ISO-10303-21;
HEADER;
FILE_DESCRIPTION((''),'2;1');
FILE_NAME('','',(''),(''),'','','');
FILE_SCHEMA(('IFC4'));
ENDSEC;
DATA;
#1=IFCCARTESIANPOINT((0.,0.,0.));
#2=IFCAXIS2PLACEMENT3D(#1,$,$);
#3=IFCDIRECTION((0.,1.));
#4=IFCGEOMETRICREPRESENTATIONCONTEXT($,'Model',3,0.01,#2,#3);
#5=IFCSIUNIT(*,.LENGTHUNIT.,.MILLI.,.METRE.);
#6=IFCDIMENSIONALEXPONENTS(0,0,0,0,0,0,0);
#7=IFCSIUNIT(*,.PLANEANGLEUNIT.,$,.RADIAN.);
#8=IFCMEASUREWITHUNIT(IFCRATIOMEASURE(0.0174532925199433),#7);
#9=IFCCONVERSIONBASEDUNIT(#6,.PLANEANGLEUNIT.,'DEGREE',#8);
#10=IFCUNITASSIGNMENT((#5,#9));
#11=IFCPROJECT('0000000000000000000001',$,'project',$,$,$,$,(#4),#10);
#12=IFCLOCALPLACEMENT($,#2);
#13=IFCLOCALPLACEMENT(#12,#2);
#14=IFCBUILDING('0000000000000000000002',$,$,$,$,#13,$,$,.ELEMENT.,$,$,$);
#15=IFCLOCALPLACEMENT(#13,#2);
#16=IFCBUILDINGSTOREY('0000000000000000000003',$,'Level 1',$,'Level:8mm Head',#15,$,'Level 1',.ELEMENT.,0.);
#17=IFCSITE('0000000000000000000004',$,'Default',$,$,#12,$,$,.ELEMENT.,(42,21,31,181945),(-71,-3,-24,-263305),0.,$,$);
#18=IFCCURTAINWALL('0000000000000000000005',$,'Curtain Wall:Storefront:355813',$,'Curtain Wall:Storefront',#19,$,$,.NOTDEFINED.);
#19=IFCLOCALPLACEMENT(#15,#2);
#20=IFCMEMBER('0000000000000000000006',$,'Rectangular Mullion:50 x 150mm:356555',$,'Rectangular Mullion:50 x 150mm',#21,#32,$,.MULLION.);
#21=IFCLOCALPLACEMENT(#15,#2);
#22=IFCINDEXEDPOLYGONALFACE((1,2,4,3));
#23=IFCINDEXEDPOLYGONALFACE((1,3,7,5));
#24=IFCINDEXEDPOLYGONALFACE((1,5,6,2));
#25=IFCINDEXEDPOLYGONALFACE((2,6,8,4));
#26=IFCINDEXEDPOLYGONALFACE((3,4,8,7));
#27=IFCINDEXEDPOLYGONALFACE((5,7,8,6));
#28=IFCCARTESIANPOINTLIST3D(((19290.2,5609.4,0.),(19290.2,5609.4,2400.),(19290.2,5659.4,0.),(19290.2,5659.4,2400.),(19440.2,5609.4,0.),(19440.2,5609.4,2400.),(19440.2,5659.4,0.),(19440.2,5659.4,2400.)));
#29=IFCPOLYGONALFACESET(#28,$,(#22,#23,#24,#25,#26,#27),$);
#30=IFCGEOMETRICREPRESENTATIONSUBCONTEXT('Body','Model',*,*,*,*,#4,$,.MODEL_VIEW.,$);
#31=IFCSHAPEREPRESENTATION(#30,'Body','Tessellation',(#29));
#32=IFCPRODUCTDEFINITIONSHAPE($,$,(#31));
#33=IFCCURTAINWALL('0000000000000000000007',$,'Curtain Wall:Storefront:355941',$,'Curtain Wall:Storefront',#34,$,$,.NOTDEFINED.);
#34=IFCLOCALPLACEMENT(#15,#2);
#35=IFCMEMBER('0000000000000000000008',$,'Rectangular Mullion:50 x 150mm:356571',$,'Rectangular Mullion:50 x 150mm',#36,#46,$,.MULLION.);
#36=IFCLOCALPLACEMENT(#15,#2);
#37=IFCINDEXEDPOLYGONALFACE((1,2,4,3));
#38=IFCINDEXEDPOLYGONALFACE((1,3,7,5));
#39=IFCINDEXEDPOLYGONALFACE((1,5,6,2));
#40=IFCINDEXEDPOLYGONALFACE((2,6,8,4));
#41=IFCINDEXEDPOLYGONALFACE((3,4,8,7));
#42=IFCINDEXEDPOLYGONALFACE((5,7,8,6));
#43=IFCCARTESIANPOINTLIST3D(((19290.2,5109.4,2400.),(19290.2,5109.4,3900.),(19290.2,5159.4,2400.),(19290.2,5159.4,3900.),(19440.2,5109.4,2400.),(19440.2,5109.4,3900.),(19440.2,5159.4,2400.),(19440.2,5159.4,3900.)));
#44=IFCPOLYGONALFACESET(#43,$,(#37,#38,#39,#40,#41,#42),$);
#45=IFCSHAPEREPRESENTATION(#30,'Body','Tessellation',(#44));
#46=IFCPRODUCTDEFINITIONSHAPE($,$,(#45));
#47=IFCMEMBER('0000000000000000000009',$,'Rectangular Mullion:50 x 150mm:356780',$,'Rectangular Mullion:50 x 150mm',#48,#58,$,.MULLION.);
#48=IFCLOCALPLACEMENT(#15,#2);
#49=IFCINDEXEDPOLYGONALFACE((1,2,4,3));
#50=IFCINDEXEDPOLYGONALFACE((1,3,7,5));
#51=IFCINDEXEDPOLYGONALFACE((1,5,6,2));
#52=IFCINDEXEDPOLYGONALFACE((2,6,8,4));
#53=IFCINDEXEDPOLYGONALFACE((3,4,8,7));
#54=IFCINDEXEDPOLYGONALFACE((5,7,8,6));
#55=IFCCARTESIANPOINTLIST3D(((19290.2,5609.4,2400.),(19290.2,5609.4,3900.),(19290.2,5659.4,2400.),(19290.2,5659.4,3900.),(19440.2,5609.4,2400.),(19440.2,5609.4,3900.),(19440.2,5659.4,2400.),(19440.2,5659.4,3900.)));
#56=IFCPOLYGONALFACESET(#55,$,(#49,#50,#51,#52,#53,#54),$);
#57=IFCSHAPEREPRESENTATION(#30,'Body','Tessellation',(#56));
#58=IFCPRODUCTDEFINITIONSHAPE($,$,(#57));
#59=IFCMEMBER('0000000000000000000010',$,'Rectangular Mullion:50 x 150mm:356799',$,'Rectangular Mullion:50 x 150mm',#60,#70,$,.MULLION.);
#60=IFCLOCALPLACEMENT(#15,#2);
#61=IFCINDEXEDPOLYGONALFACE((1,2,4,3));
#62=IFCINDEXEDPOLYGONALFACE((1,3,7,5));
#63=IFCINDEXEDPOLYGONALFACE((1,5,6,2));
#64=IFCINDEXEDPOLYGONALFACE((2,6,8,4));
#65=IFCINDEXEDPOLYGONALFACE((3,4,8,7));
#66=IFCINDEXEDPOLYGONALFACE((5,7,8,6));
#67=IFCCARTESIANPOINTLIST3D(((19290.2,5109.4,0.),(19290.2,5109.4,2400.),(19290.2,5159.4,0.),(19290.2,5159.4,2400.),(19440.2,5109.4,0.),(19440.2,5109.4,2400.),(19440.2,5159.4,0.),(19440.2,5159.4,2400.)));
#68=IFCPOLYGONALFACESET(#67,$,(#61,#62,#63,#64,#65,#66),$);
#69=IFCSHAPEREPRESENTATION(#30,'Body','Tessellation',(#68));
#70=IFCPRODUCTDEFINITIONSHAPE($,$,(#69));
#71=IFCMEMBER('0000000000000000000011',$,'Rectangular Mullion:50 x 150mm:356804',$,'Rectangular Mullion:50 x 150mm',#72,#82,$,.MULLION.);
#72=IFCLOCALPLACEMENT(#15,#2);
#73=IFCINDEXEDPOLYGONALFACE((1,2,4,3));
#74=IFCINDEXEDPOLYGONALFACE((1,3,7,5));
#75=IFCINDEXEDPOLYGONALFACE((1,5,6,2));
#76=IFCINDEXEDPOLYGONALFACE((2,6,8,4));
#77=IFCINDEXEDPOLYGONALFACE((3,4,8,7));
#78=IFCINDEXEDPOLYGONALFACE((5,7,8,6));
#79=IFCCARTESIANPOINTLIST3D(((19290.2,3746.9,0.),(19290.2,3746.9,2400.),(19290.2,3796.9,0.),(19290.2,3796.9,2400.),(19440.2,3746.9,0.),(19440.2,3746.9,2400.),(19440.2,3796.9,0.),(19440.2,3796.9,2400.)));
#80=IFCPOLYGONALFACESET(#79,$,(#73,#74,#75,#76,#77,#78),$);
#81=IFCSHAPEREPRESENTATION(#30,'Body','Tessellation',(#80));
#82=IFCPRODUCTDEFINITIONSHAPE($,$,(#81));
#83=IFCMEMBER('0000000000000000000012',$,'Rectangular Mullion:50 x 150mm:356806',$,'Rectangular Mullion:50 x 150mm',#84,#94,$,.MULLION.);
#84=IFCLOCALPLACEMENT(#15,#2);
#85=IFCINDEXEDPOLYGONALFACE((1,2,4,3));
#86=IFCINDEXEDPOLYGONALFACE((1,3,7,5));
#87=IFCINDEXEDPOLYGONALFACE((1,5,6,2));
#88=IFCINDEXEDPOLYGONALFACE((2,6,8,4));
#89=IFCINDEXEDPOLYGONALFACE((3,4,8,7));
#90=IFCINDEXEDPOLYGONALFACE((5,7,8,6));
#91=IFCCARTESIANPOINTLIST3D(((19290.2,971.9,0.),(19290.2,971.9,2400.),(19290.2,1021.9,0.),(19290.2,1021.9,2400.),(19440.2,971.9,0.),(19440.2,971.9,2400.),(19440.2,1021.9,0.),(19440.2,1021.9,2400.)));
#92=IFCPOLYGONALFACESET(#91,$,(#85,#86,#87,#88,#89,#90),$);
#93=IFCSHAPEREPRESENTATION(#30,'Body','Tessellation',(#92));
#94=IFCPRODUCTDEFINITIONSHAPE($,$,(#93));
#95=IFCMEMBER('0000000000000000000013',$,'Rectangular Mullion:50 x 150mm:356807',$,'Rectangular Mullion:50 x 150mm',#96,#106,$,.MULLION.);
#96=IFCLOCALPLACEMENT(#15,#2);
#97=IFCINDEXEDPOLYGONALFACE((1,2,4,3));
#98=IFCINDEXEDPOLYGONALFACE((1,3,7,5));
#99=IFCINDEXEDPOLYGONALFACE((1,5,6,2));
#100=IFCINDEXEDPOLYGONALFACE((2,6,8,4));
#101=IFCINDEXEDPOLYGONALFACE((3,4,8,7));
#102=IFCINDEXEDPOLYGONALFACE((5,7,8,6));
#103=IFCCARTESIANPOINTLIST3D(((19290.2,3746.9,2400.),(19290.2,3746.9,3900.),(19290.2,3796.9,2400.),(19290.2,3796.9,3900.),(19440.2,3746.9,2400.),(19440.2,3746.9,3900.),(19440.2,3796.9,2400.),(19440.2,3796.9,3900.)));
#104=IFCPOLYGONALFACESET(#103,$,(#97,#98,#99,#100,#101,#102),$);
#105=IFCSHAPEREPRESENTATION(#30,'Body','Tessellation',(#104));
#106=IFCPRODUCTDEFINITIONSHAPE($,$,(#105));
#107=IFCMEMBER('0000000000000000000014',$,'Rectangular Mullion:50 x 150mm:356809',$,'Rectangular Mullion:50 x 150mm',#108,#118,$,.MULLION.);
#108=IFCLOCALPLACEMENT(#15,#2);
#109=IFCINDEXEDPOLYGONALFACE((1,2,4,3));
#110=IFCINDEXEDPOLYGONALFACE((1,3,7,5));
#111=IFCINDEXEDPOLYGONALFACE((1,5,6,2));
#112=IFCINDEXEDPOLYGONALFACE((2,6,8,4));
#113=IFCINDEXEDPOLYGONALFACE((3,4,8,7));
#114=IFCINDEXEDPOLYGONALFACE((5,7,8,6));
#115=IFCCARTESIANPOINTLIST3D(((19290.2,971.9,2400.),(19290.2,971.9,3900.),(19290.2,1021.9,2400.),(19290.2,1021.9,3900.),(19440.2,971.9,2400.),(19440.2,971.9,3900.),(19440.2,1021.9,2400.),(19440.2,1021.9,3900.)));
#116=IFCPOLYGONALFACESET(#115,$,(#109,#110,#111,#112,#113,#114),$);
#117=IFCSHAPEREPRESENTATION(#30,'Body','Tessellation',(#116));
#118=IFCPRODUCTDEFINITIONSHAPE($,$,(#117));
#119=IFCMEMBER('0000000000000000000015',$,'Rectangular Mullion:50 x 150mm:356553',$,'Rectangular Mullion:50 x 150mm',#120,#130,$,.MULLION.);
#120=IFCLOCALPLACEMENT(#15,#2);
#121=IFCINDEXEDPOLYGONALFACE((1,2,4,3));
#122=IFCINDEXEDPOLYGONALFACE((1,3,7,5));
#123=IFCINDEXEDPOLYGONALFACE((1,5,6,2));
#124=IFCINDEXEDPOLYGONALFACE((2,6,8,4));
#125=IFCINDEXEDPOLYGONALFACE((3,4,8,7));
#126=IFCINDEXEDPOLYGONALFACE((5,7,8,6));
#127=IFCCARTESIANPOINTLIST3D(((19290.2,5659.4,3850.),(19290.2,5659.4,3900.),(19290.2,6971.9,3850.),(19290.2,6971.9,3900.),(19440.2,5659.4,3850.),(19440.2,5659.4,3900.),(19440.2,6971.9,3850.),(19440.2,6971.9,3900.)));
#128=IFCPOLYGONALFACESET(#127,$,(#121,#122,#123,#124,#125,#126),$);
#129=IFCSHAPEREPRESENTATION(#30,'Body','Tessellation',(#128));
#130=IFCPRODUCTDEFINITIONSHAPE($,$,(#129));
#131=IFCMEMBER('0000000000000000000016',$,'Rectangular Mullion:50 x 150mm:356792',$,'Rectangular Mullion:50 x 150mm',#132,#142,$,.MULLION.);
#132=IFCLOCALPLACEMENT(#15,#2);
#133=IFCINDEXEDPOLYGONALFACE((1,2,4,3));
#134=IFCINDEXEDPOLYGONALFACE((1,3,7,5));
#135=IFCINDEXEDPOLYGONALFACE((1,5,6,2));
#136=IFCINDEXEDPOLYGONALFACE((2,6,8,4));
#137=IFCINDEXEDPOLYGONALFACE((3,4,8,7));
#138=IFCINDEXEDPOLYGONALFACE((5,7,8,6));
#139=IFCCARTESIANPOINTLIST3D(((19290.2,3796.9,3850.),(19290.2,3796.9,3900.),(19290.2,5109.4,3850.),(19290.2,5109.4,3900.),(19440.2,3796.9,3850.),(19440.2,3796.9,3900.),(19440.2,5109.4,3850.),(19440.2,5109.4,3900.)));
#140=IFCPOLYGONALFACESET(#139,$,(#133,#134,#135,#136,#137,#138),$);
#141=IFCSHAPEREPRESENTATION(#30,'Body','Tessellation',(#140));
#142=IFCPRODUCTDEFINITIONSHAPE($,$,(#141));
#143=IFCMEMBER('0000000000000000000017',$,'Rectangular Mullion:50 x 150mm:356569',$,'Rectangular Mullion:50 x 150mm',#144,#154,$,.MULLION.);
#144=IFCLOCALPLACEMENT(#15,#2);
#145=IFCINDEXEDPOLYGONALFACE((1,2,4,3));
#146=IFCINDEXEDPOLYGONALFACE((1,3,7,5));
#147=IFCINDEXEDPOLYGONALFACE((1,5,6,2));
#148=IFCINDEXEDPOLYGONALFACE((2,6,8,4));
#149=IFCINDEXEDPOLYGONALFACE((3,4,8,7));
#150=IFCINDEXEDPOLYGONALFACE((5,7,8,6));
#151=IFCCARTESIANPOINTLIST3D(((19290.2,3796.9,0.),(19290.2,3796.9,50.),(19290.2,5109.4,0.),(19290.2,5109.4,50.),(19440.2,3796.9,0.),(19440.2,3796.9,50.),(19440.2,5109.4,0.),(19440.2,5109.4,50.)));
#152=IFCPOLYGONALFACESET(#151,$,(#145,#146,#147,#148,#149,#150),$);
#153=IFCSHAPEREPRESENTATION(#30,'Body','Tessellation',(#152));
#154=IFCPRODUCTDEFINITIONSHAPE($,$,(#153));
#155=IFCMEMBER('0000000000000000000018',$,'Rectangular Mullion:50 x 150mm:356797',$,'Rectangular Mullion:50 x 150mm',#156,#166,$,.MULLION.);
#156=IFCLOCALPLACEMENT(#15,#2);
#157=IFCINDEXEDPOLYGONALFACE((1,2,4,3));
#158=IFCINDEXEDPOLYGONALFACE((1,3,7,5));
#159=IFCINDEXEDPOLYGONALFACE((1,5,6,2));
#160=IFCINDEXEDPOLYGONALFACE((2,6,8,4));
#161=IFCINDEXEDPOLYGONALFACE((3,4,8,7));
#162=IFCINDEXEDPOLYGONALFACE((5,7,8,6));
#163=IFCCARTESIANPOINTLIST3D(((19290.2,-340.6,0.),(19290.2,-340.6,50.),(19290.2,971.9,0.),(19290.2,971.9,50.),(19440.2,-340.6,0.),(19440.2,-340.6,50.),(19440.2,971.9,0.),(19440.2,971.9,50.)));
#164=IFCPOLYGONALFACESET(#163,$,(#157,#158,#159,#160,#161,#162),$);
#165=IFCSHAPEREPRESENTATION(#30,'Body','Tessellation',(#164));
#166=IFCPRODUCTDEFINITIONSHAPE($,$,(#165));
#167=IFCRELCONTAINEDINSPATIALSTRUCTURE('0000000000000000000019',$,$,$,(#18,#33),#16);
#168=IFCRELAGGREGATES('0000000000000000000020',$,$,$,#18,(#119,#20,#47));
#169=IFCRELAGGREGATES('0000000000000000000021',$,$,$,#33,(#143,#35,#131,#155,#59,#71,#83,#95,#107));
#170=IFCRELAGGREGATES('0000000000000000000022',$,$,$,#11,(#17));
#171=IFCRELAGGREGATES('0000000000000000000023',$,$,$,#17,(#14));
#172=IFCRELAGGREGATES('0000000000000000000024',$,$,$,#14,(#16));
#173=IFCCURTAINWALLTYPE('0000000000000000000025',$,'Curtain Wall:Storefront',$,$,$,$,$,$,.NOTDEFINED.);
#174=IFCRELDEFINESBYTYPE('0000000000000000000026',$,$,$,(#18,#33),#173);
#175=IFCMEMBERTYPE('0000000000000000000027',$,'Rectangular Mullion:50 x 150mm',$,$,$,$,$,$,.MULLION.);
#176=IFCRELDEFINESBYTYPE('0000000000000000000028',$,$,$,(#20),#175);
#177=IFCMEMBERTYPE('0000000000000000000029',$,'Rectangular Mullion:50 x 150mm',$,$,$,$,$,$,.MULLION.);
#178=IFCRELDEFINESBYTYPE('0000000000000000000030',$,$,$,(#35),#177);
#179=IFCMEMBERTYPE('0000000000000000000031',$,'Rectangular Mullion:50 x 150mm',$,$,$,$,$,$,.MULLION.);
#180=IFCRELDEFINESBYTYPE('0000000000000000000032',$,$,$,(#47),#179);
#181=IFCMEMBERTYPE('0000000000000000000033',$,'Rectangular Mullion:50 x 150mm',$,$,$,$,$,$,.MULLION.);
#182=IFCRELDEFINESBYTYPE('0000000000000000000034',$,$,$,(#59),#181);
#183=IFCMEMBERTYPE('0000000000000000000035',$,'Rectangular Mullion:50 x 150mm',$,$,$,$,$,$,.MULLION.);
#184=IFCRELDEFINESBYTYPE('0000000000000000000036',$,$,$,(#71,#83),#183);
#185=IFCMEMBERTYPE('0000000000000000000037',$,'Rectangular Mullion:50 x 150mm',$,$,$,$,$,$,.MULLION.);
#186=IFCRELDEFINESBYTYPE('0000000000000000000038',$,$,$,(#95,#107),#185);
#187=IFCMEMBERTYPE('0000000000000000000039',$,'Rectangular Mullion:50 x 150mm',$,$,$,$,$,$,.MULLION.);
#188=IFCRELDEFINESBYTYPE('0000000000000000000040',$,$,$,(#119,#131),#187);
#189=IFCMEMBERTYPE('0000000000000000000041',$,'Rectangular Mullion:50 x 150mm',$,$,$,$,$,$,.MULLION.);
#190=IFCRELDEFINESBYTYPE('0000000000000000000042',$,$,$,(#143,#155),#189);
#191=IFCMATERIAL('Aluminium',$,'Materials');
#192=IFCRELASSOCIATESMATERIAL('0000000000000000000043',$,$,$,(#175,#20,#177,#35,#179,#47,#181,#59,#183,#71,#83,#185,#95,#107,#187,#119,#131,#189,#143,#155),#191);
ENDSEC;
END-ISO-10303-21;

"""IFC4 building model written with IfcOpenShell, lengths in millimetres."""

from ifc_helpers import new_model, entity, si_unit, converted_unit, direction, frame, origin, place, context, subcontext, project, spatial, indexed_curve, outline, extrude, source, transform, mapped, material, type_object, type_shapes, element, aggregate, save


model = new_model("IFC4")

# Units and contexts
model_context = context("Model", 3, precision=0.01, world=origin(), true_north=direction((0.0, 1.0)))
body_context = subcontext(model_context, "Body", "Model", "MODEL_VIEW")
ifc_project = project(units=[si_unit("LENGTHUNIT", "METRE", prefix="MILLI"), converted_unit("PLANEANGLEUNIT", "DEGREE", entity("IfcRatioMeasure", 0.0174532925199433), si_unit("PLANEANGLEUNIT", "RADIAN"), dimensions=[0, 0, 0, 0, 0, 0, 0])], contexts=[model_context])

# Site, building, storey
site_placement = place(None, origin())
site = spatial("IfcSite", under=ifc_project, at=site_placement, Name="Default", CompositionType="ELEMENT", RefLatitude=(42, 21, 31, 181945), RefLongitude=(-71, -3, -24, -263305), RefElevation=0.0)
building_placement = place(site_placement, origin())
building = spatial("IfcBuilding", under=site, at=building_placement, CompositionType="ELEMENT")
storey_placement = place(building_placement, origin())
storey = spatial("IfcBuildingStorey", under=building, at=storey_placement, Name="Level 1", ObjectType="Level:8mm Head", LongName="Level 1", CompositionType="ELEMENT", Elevation=0.0)

# Curtain walls, members
curtain_wall_type_1 = type_object("IfcCurtainWallType", Name="Curtain Wall:Storefront", PredefinedType="NOTDEFINED")
curtain_wall_1_placement = place(storey_placement, origin())
curtain_wall_1 = element("IfcCurtainWall", 1, at=curtain_wall_1_placement, inside=storey, type_object=curtain_wall_type_1, Name="Curtain Wall:Storefront:355813", ObjectType="Curtain Wall:Storefront", PredefinedType="NOTDEFINED")
ifc_material_1 = material(Name="Aluminium", Category="Materials")
member_type_1 = type_object("IfcMemberType", Name="Rectangular Mullion:50 x 150mm", PredefinedType="MULLION", material=ifc_material_1)
shared_shape_1 = source(origin(), body_context, "Body", "SweptSolid", [
    extrude(outline(indexed_curve([(-75.0, -25.0), (75.0, -25.0), (75.0, 25.0), (-75.0, 25.0), (-75.0, -25.0)], self_intersect=False)), frame((-25.0, 0.0, -2400.0), z_axis=(0.0, 0.0, 1.0), x_axis=(0.0, -1.0, 0.0)), (0.0, 0.0, 1.0), 2400.0),
])
type_shapes(member_type_1, [shared_shape_1])
member_1_placement = place(storey_placement, frame((19365.2, 5609.4, 0.0), z_axis=(0.0, 0.0, -1.0), x_axis=(0.0, -1.0, 0.0)))
member_1 = element("IfcMember", 2, at=member_1_placement, type_object=member_type_1, material=ifc_material_1, Name="Rectangular Mullion:50 x 150mm:356555", ObjectType="Rectangular Mullion:50 x 150mm", PredefinedType="MULLION", context=body_context, shape_type="MappedRepresentation", body=[
    mapped(shared_shape_1, transform((0.0, 0.0, 0.0), scale=1.0)),
])
curtain_wall_2_placement = place(storey_placement, origin())
curtain_wall_2 = element("IfcCurtainWall", 3, at=curtain_wall_2_placement, inside=storey, type_object=curtain_wall_type_1, Name="Curtain Wall:Storefront:355941", ObjectType="Curtain Wall:Storefront", PredefinedType="NOTDEFINED")
member_type_2 = type_object("IfcMemberType", Name="Rectangular Mullion:50 x 150mm", PredefinedType="MULLION", material=ifc_material_1)
shared_shape_2 = source(origin(), body_context, "Body", "SweptSolid", [
    extrude(outline(indexed_curve([(-75.0, -25.0), (75.0, -25.0), (75.0, 25.0), (-75.0, 25.0), (-75.0, -25.0)], self_intersect=False)), frame((-25.0, 0.0, -1500.0), z_axis=(0.0, 0.0, 1.0), x_axis=(0.0, -1.0, 0.0)), (0.0, 0.0, 1.0), 1500.0),
])
type_shapes(member_type_2, [shared_shape_2])
member_2_placement = place(storey_placement, frame((19365.2, 5159.4, 3900.0), z_axis=(0.0, 0.0, 1.0), x_axis=(0.0, 1.0, 0.0)))
member_2 = element("IfcMember", 4, at=member_2_placement, type_object=member_type_2, material=ifc_material_1, Name="Rectangular Mullion:50 x 150mm:356571", ObjectType="Rectangular Mullion:50 x 150mm", PredefinedType="MULLION", context=body_context, shape_type="MappedRepresentation", body=[
    mapped(shared_shape_2, transform((0.0, 0.0, 0.0), scale=1.0)),
])

# Members
member_type_3 = type_object("IfcMemberType", Name="Rectangular Mullion:50 x 150mm", PredefinedType="MULLION", material=ifc_material_1)
shared_shape_3 = source(origin(), body_context, "Body", "SweptSolid", [
    extrude(outline(indexed_curve([(-75.0, -25.0), (75.0, -25.0), (75.0, 25.0), (-75.0, 25.0), (-75.0, -25.0)], self_intersect=False)), frame((-25.0, 0.0, -1500.0), z_axis=(0.0, 0.0, 1.0), x_axis=(0.0, -1.0, 0.0)), (0.0, 0.0, 1.0), 1500.0),
])
type_shapes(member_type_3, [shared_shape_3])
member_3_placement = place(storey_placement, frame((19365.2, 5609.4, 2400.0), z_axis=(0.0, 0.0, -1.0), x_axis=(0.0, -1.0, 0.0)))
member_3 = element("IfcMember", 5, at=member_3_placement, type_object=member_type_3, material=ifc_material_1, Name="Rectangular Mullion:50 x 150mm:356780", ObjectType="Rectangular Mullion:50 x 150mm", PredefinedType="MULLION", context=body_context, shape_type="MappedRepresentation", body=[
    mapped(shared_shape_3, transform((0.0, 0.0, 0.0), scale=1.0)),
])
member_type_4 = type_object("IfcMemberType", Name="Rectangular Mullion:50 x 150mm", PredefinedType="MULLION", material=ifc_material_1)
shared_shape_4 = source(origin(), body_context, "Body", "SweptSolid", [
    extrude(outline(indexed_curve([(-75.0, -25.0), (75.0, -25.0), (75.0, 25.0), (-75.0, 25.0), (-75.0, -25.0)], self_intersect=False)), frame((-25.0, 0.0, -2400.0), z_axis=(0.0, 0.0, 1.0), x_axis=(0.0, -1.0, 0.0)), (0.0, 0.0, 1.0), 2400.0),
])
type_shapes(member_type_4, [shared_shape_4])
member_4_placement = place(storey_placement, frame((19365.2, 5159.4, 2400.0), z_axis=(0.0, 0.0, 1.0), x_axis=(0.0, 1.0, 0.0)))
member_4 = element("IfcMember", 6, at=member_4_placement, type_object=member_type_4, material=ifc_material_1, Name="Rectangular Mullion:50 x 150mm:356799", ObjectType="Rectangular Mullion:50 x 150mm", PredefinedType="MULLION", context=body_context, shape_type="MappedRepresentation", body=[
    mapped(shared_shape_4, transform((0.0, 0.0, 0.0), scale=1.0)),
])
member_type_5 = type_object("IfcMemberType", Name="Rectangular Mullion:50 x 150mm", PredefinedType="MULLION", material=ifc_material_1)
shared_shape_5 = source(origin(), body_context, "Body", "SweptSolid", [
    extrude(outline(indexed_curve([(-75.0, -25.0), (75.0, -25.0), (75.0, 25.0), (-75.0, 25.0), (-75.0, -25.0)], self_intersect=False)), frame((0.0, 0.0, -2400.0), z_axis=(0.0, 0.0, 1.0), x_axis=(0.0, -1.0, 0.0)), (0.0, 0.0, 1.0), 2400.0),
])
type_shapes(member_type_5, [shared_shape_5])
member_5_placement = place(storey_placement, frame((19365.2, 3771.9, 0.0), z_axis=(0.0, 0.0, -1.0), x_axis=(0.0, -1.0, 0.0)))
member_5 = element("IfcMember", 7, at=member_5_placement, type_object=member_type_5, material=ifc_material_1, Name="Rectangular Mullion:50 x 150mm:356804", ObjectType="Rectangular Mullion:50 x 150mm", PredefinedType="MULLION", context=body_context, shape_type="MappedRepresentation", body=[
    mapped(shared_shape_5, transform((0.0, 0.0, 0.0), scale=1.0)),
])
member_6_placement = place(storey_placement, frame((19365.2, 996.9, 0.0), z_axis=(0.0, 0.0, -1.0), x_axis=(0.0, -1.0, 0.0)))
member_6 = element("IfcMember", 8, at=member_6_placement, type_object=member_type_5, material=ifc_material_1, Name="Rectangular Mullion:50 x 150mm:356806", ObjectType="Rectangular Mullion:50 x 150mm", PredefinedType="MULLION", context=body_context, shape_type="MappedRepresentation", body=[
    mapped(shared_shape_5, transform((0.0, 0.0, 0.0), scale=1.0)),
])
member_type_6 = type_object("IfcMemberType", Name="Rectangular Mullion:50 x 150mm", PredefinedType="MULLION", material=ifc_material_1)
shared_shape_6 = source(origin(), body_context, "Body", "SweptSolid", [
    extrude(outline(indexed_curve([(-75.0, -25.0), (75.0, -25.0), (75.0, 25.0), (-75.0, 25.0), (-75.0, -25.0)], self_intersect=False)), frame((0.0, 0.0, -1500.0), z_axis=(0.0, 0.0, 1.0), x_axis=(0.0, -1.0, 0.0)), (0.0, 0.0, 1.0), 1500.0),
])
type_shapes(member_type_6, [shared_shape_6])
member_7_placement = place(storey_placement, frame((19365.2, 3771.9, 2400.0), z_axis=(0.0, 0.0, -1.0), x_axis=(0.0, -1.0, 0.0)))
member_7 = element("IfcMember", 9, at=member_7_placement, type_object=member_type_6, material=ifc_material_1, Name="Rectangular Mullion:50 x 150mm:356807", ObjectType="Rectangular Mullion:50 x 150mm", PredefinedType="MULLION", context=body_context, shape_type="MappedRepresentation", body=[
    mapped(shared_shape_6, transform((0.0, 0.0, 0.0), scale=1.0)),
])
member_8_placement = place(storey_placement, frame((19365.2, 996.9, 2400.0), z_axis=(0.0, 0.0, -1.0), x_axis=(0.0, -1.0, 0.0)))
member_8 = element("IfcMember", 10, at=member_8_placement, type_object=member_type_6, material=ifc_material_1, Name="Rectangular Mullion:50 x 150mm:356809", ObjectType="Rectangular Mullion:50 x 150mm", PredefinedType="MULLION", context=body_context, shape_type="MappedRepresentation", body=[
    mapped(shared_shape_6, transform((0.0, 0.0, 0.0), scale=1.0)),
])
member_type_7 = type_object("IfcMemberType", Name="Rectangular Mullion:50 x 150mm", PredefinedType="MULLION", material=ifc_material_1)
shared_shape_7 = source(origin(), body_context, "Body", "SweptSolid", [
    extrude(outline(indexed_curve([(-75.0, -25.0), (75.0, -25.0), (75.0, 25.0), (-75.0, 25.0), (-75.0, -25.0)], self_intersect=False)), frame((-25.0, 0.0, -1312.5), z_axis=(0.0, 0.0, 1.0), x_axis=(0.0, -1.0, 0.0)), (0.0, 0.0, 1.0), 1312.5),
])
type_shapes(member_type_7, [shared_shape_7])
member_9_placement = place(storey_placement, frame((19365.2, 5659.4, 3900.0), z_axis=(0.0, -1.0, 0.0), x_axis=(0.0, 0.0, 1.0)))
member_9 = element("IfcMember", 11, at=member_9_placement, type_object=member_type_7, material=ifc_material_1, Name="Rectangular Mullion:50 x 150mm:356553", ObjectType="Rectangular Mullion:50 x 150mm", PredefinedType="MULLION", context=body_context, shape_type="MappedRepresentation", body=[
    mapped(shared_shape_7, transform((0.0, 0.0, 0.0), scale=1.0)),
])
member_10_placement = place(storey_placement, frame((19365.2, 3796.9, 3900.0), z_axis=(0.0, -1.0, 0.0), x_axis=(0.0, 0.0, 1.0)))
member_10 = element("IfcMember", 12, at=member_10_placement, type_object=member_type_7, material=ifc_material_1, Name="Rectangular Mullion:50 x 150mm:356792", ObjectType="Rectangular Mullion:50 x 150mm", PredefinedType="MULLION", context=body_context, shape_type="MappedRepresentation", body=[
    mapped(shared_shape_7, transform((0.0, 0.0, 0.0), scale=1.0)),
])
member_type_8 = type_object("IfcMemberType", Name="Rectangular Mullion:50 x 150mm", PredefinedType="MULLION", material=ifc_material_1)
shared_shape_8 = source(origin(), body_context, "Body", "SweptSolid", [
    extrude(outline(indexed_curve([(-75.0, -25.0), (75.0, -25.0), (75.0, 25.0), (-75.0, 25.0), (-75.0, -25.0)], self_intersect=False)), frame((-25.0, 0.0, -1312.5), z_axis=(0.0, 0.0, 1.0), x_axis=(0.0, -1.0, 0.0)), (0.0, 0.0, 1.0), 1312.5),
])
type_shapes(member_type_8, [shared_shape_8])
member_11_placement = place(storey_placement, frame((19365.2, 5109.4, 0.0), z_axis=(0.0, 1.0, 0.0), x_axis=(0.0, 0.0, -1.0)))
member_11 = element("IfcMember", 13, at=member_11_placement, type_object=member_type_8, material=ifc_material_1, Name="Rectangular Mullion:50 x 150mm:356569", ObjectType="Rectangular Mullion:50 x 150mm", PredefinedType="MULLION", context=body_context, shape_type="MappedRepresentation", body=[
    mapped(shared_shape_8, transform((0.0, 0.0, 0.0), scale=1.0)),
])
member_12_placement = place(storey_placement, frame((19365.2, 971.9, 0.0), z_axis=(0.0, 1.0, 0.0), x_axis=(0.0, 0.0, -1.0)))
member_12 = element("IfcMember", 14, at=member_12_placement, type_object=member_type_8, material=ifc_material_1, Name="Rectangular Mullion:50 x 150mm:356797", ObjectType="Rectangular Mullion:50 x 150mm", PredefinedType="MULLION", context=body_context, shape_type="MappedRepresentation", body=[
    mapped(shared_shape_8, transform((0.0, 0.0, 0.0), scale=1.0)),
])

aggregate(curtain_wall_1, [member_9, member_1, member_3])

aggregate(curtain_wall_2, [member_11, member_2, member_10, member_12, member_4, member_5, member_6, member_7, member_8])

save(model, "model.ifc")
